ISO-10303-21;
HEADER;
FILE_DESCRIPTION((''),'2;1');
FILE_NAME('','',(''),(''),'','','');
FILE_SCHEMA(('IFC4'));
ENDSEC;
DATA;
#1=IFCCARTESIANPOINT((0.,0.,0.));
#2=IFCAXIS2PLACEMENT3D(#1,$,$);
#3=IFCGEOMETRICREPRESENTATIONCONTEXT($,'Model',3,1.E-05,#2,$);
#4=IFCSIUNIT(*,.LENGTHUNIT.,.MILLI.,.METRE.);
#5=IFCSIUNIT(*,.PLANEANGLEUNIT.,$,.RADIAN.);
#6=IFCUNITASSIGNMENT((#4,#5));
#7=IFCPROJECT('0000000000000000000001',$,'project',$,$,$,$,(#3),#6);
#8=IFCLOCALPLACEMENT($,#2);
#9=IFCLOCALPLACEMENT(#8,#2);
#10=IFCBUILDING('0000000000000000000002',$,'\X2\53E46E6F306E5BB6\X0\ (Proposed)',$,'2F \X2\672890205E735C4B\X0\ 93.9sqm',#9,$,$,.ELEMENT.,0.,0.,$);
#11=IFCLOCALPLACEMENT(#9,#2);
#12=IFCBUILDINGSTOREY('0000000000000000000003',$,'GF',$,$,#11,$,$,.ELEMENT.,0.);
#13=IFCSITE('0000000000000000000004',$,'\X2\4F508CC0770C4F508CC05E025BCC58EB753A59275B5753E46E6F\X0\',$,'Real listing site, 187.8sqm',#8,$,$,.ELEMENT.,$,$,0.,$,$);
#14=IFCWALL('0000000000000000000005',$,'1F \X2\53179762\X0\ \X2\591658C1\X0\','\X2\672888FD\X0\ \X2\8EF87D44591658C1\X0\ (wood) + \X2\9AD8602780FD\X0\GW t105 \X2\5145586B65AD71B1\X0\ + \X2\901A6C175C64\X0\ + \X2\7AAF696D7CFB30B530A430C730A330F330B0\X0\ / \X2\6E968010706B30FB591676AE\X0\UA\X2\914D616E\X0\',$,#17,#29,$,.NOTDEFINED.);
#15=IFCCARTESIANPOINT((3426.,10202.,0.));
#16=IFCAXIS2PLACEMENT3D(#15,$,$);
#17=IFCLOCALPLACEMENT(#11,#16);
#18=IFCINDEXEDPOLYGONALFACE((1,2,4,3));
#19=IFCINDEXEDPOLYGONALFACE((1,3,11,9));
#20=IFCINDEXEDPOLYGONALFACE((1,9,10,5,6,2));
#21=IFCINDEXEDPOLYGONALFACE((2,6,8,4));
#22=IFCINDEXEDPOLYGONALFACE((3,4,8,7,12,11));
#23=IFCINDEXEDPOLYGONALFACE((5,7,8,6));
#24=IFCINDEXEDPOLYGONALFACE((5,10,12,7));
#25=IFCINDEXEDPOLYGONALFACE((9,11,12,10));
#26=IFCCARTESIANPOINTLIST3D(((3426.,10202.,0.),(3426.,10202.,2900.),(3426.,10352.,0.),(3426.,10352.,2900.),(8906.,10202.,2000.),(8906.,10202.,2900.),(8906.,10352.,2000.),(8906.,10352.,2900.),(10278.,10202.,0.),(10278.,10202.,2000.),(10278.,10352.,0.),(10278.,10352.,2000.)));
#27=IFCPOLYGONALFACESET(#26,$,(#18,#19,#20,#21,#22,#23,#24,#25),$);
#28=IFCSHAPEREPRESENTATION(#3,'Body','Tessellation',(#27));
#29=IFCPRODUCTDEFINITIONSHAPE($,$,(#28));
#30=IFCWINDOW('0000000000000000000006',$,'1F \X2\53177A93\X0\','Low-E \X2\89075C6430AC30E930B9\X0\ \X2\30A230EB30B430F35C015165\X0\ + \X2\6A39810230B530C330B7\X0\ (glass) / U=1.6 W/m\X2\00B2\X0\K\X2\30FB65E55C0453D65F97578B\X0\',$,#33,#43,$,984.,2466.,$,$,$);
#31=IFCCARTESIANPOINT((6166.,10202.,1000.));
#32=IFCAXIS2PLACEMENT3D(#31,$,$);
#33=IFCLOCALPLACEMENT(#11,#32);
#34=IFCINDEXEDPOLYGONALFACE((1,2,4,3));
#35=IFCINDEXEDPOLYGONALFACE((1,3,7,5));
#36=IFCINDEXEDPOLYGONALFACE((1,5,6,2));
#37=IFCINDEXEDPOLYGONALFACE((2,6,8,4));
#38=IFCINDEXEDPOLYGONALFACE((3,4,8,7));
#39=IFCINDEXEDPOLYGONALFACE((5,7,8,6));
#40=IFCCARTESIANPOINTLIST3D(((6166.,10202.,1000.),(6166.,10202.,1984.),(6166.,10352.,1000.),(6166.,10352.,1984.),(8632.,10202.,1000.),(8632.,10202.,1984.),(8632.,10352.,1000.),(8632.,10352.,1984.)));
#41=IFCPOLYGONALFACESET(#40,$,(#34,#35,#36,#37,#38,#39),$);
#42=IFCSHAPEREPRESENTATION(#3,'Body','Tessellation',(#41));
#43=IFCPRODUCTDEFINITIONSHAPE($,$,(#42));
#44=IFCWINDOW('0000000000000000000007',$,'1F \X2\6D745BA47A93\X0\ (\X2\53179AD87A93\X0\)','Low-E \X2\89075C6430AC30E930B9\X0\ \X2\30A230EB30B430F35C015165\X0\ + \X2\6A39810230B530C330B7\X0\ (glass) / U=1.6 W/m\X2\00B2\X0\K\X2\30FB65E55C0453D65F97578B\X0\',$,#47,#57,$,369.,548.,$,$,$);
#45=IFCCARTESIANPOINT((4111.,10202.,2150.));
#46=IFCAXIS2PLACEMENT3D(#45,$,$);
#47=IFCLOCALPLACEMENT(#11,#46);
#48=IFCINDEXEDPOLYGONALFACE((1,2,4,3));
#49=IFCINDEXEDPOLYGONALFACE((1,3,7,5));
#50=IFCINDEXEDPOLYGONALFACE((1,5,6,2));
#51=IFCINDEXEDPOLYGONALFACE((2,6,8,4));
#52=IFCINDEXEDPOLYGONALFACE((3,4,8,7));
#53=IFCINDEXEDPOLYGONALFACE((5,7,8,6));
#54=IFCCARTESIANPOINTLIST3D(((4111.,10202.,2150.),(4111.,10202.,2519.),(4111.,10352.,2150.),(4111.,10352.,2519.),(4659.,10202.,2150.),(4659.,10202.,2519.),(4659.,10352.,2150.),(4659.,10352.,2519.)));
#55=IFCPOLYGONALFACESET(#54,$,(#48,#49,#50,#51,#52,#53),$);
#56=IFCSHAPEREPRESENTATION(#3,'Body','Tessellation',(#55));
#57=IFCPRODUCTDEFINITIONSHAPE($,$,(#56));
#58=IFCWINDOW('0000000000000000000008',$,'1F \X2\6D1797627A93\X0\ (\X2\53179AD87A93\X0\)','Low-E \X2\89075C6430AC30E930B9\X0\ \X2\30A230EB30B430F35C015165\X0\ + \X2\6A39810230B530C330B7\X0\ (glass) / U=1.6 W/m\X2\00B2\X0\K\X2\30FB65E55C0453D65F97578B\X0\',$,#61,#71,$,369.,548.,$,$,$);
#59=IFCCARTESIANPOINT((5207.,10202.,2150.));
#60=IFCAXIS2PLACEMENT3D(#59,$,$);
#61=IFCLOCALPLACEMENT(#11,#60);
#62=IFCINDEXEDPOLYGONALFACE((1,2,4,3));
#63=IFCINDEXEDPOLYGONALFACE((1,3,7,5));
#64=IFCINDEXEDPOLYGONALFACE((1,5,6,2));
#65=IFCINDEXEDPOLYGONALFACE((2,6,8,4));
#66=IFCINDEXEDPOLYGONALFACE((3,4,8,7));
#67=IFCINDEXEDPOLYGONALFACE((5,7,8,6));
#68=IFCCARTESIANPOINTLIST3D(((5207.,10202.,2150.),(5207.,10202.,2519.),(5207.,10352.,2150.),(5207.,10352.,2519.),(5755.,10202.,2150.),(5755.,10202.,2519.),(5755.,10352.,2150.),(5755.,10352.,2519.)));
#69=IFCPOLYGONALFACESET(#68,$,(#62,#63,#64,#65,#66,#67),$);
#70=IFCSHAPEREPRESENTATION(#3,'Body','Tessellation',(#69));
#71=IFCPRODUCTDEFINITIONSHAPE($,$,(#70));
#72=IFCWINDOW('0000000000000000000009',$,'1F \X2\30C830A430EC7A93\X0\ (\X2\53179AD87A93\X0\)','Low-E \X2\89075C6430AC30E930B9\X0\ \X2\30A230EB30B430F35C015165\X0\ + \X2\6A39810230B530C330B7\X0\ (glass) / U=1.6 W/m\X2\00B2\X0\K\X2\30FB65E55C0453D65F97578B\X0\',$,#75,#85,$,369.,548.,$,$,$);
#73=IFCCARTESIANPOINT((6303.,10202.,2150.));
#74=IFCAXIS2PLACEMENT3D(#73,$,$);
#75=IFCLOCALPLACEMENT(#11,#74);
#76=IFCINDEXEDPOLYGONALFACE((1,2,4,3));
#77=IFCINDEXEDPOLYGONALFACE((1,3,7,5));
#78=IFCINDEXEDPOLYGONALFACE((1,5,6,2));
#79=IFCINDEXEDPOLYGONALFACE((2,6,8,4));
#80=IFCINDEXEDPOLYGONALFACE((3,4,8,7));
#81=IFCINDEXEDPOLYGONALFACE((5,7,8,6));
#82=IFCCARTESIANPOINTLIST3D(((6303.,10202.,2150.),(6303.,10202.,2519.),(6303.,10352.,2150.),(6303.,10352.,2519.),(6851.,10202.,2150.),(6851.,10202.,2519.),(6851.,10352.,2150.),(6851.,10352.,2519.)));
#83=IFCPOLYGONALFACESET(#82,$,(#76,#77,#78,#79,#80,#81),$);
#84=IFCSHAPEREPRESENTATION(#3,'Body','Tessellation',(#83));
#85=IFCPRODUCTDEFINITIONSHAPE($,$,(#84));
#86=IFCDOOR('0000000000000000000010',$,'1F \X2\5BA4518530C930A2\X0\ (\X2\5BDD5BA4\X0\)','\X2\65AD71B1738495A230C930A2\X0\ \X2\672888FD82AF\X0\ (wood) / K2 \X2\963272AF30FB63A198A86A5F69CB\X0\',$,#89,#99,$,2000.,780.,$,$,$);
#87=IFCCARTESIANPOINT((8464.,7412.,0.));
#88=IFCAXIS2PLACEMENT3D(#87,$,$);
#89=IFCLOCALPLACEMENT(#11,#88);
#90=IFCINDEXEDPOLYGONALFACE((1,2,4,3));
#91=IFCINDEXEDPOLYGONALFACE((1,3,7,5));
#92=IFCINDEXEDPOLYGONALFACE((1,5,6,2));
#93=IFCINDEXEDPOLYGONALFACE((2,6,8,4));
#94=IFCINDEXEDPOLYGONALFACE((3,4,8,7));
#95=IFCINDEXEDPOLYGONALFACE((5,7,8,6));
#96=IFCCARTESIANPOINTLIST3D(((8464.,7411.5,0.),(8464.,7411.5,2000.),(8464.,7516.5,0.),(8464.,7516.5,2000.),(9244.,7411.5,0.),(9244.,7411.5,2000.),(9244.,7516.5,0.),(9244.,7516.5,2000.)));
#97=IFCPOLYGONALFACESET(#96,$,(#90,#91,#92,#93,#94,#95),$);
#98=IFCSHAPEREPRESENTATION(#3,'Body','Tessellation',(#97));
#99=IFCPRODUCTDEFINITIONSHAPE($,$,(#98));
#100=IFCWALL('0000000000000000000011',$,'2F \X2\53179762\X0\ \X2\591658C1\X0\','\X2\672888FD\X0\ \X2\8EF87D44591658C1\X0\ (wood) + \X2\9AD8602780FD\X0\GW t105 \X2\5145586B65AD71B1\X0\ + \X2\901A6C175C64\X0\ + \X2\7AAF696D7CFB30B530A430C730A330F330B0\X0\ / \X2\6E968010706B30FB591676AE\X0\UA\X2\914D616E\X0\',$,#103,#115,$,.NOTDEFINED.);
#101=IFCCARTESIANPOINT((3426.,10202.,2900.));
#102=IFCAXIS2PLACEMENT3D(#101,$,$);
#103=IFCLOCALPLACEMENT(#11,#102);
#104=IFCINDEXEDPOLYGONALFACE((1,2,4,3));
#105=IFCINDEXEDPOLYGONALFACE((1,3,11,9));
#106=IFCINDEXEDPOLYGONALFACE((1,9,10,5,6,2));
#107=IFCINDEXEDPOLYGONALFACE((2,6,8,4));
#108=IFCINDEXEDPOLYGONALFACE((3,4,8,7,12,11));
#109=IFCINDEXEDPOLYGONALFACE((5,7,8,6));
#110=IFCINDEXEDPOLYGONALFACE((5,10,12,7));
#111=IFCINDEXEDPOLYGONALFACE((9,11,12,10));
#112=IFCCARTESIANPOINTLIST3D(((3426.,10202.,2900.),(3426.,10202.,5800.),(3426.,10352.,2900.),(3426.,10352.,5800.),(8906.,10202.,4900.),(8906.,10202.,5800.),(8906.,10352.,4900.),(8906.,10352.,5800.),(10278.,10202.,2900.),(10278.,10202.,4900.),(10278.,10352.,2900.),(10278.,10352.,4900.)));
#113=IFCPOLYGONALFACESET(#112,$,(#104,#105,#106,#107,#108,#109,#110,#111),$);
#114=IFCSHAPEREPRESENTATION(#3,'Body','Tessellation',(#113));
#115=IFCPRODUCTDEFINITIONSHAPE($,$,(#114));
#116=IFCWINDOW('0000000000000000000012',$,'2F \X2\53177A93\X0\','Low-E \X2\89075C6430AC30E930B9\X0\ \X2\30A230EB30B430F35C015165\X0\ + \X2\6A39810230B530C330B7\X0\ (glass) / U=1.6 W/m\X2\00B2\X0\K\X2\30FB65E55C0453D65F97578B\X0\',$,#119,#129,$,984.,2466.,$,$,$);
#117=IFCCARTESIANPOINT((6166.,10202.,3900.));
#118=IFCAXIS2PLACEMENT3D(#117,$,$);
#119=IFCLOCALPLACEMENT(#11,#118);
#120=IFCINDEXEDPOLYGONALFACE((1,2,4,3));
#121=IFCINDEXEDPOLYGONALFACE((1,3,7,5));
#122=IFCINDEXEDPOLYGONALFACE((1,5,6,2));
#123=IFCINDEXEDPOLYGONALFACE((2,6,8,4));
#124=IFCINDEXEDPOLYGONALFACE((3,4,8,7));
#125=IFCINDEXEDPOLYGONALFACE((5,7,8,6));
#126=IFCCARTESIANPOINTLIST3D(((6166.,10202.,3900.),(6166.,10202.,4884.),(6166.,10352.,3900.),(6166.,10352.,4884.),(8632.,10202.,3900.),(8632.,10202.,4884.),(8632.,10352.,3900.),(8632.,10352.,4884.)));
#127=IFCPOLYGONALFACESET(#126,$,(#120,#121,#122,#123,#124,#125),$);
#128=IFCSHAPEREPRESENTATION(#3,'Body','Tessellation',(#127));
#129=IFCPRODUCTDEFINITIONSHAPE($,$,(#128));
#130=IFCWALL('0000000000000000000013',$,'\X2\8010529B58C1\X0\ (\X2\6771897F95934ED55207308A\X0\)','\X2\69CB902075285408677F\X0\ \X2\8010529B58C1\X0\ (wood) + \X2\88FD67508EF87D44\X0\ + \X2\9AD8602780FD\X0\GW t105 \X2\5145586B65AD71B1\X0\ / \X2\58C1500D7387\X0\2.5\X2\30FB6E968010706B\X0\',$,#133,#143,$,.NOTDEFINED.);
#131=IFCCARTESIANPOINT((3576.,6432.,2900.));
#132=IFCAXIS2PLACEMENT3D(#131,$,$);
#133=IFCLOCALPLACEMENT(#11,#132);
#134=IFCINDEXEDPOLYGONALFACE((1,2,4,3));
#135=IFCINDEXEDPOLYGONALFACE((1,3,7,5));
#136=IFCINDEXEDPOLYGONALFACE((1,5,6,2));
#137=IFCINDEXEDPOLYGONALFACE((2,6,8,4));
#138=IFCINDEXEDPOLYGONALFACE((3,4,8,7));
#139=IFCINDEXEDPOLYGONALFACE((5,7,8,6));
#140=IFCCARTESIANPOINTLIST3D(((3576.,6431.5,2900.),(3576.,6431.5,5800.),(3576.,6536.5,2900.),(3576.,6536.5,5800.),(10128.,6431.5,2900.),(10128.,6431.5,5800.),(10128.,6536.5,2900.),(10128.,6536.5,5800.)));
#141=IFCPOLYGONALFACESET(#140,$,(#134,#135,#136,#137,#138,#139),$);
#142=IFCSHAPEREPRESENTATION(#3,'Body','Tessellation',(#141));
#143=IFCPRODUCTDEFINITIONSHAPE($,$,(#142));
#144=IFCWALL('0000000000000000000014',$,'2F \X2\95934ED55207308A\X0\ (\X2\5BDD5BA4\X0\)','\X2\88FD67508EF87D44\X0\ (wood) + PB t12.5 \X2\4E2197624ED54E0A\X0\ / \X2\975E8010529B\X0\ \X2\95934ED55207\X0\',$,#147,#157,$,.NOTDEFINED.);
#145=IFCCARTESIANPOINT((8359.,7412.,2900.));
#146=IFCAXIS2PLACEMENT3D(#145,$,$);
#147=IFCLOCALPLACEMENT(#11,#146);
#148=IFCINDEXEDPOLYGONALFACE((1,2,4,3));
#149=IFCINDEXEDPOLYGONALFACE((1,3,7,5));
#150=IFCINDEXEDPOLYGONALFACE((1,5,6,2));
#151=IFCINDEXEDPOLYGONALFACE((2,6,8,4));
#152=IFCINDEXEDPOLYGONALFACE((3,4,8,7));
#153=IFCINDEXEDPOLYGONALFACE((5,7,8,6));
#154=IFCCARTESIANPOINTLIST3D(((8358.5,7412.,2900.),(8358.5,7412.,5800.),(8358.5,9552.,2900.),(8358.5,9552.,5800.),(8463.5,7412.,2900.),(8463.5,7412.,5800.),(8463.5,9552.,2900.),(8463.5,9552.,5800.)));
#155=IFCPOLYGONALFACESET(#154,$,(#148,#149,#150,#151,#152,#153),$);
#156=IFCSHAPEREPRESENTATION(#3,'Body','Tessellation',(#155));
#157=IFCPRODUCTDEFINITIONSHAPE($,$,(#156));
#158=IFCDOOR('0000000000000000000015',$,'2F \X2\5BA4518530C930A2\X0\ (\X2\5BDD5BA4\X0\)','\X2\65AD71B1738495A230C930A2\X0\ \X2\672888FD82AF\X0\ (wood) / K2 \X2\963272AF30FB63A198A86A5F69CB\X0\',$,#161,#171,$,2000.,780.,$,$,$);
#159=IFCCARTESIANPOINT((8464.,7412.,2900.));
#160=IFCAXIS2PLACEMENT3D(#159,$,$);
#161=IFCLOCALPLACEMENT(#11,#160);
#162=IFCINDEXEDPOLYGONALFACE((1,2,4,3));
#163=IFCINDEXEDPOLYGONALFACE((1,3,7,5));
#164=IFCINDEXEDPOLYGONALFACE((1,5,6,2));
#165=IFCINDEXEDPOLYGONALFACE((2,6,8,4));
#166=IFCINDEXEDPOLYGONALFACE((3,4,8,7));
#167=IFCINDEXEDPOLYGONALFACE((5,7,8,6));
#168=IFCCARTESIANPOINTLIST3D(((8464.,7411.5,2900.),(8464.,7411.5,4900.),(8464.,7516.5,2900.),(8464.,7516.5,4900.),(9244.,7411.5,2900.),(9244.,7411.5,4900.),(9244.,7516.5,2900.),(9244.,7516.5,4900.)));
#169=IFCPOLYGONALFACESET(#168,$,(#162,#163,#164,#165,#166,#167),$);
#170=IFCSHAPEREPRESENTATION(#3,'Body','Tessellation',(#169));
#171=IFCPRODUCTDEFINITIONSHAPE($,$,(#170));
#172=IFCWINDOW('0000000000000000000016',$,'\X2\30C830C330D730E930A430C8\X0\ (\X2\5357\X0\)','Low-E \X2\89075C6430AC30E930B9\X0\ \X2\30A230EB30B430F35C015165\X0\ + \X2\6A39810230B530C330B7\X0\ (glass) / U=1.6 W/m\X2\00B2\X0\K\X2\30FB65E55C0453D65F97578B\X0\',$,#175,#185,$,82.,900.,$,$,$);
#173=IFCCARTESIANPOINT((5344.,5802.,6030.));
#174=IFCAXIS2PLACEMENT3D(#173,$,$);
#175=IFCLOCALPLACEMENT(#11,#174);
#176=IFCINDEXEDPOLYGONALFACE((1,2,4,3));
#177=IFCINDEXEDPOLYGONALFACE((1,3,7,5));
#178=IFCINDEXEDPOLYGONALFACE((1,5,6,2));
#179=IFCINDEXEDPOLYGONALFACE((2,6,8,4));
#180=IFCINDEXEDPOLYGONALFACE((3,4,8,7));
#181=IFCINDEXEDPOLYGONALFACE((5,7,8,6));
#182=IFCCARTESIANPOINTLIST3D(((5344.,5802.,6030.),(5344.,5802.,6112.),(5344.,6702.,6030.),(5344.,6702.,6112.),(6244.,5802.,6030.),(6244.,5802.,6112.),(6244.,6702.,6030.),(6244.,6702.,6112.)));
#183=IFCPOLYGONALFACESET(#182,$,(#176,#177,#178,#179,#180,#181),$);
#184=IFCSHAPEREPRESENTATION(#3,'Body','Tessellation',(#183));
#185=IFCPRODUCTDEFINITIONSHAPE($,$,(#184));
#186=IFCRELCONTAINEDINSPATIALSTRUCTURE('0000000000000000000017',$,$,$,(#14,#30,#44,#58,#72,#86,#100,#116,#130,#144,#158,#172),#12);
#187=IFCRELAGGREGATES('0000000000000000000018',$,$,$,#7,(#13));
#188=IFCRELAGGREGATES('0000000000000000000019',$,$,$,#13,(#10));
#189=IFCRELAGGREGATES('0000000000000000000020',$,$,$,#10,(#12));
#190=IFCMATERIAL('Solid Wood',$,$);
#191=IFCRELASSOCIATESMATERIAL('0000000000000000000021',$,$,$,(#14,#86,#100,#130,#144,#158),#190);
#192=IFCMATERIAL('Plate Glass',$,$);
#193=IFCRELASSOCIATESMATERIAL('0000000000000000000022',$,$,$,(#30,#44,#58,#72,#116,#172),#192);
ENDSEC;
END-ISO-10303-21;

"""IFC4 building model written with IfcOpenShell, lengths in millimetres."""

from ifc_helpers import new_model, si_unit, frame, frame_2d, origin, place, context, project, spatial, rectangle, extrude, material, element, fill, save


model = new_model("IFC4")

# Units and contexts
model_context = context("Model", 3, precision=1e-05, world=origin())
ifc_project = project(units=[si_unit("LENGTHUNIT", "METRE", prefix="MILLI"), si_unit("PLANEANGLEUNIT", "RADIAN")], contexts=[model_context])

# Site, building, storey
site_placement = place(None, origin())
site = spatial("IfcSite", under=ifc_project, at=site_placement, Name="佐賀県佐賀市富士町大字古湯", ObjectType="Real listing site, 187.8sqm", CompositionType="ELEMENT", RefElevation=0.0)
building_placement = place(site_placement, origin())
building = spatial("IfcBuilding", under=site, at=building_placement, Name="古湯の家 (Proposed)", ObjectType="2F 木造平屋 93.9sqm", CompositionType="ELEMENT", ElevationOfRefHeight=0.0, ElevationOfTerrain=0.0)
storey_placement = place(building_placement, origin())
storey = spatial("IfcBuildingStorey", under=building, at=storey_placement, Name="GF", CompositionType="ELEMENT", Elevation=0.0)

# Wall, openings, windows
ifc_material_1 = material(Name="Solid Wood")
wall_1_placement = place(storey_placement, frame((3426.0, 10202.0, 0.0)))
wall_1 = element("IfcWall", 1, at=wall_1_placement, inside=storey, material=ifc_material_1, Name="1F 北面 外壁", Description="木製 軸組外壁 (wood) + 高性能GW t105 充填断熱 + 通気層 + 窯業系サイディング / 準耐火・外皮UA配慮", PredefinedType="NOTDEFINED", context=model_context, shape_type="SweptSolid", body=[
    extrude(rectangle(XDim=6852.0, YDim=150.0, at=frame_2d((3426.0, 75.0))), frame((3426.0, 10202.0, 0.0)), (0.0, 0.0, 1.0), 2900.0),
])
opening_1_placement = place(storey_placement, frame((6166.0, 10202.0, 1000.0)))
opening_1 = element("IfcOpeningElement", 2, at=opening_1_placement, cuts=wall_1, PredefinedType="NOTDEFINED", context=model_context, shape_type="SweptSolid", body=[
    extrude(rectangle(XDim=2466.0, YDim=150.0, at=frame_2d((1233.0, 75.0))), frame((6166.0, 10202.0, 1000.0)), (0.0, 0.0, 1.0), 984.0),
])
opening_2_placement = place(storey_placement, frame((4111.0, 10202.0, 2150.0)))
opening_2 = element("IfcOpeningElement", 3, at=opening_2_placement, cuts=wall_1, PredefinedType="NOTDEFINED", context=model_context, shape_type="SweptSolid", body=[
    extrude(rectangle(XDim=548.0, YDim=150.0, at=frame_2d((274.0, 75.0))), frame((4111.0, 10202.0, 2150.0)), (0.0, 0.0, 1.0), 369.0),
])
opening_3_placement = place(storey_placement, frame((5207.0, 10202.0, 2150.0)))
opening_3 = element("IfcOpeningElement", 4, at=opening_3_placement, cuts=wall_1, PredefinedType="NOTDEFINED", context=model_context, shape_type="SweptSolid", body=[
    extrude(rectangle(XDim=548.0, YDim=150.0, at=frame_2d((274.0, 75.0))), frame((5207.0, 10202.0, 2150.0)), (0.0, 0.0, 1.0), 369.0),
])
opening_4_placement = place(storey_placement, frame((6303.0, 10202.0, 2150.0)))
opening_4 = element("IfcOpeningElement", 5, at=opening_4_placement, cuts=wall_1, PredefinedType="NOTDEFINED", context=model_context, shape_type="SweptSolid", body=[
    extrude(rectangle(XDim=548.0, YDim=150.0, at=frame_2d((274.0, 75.0))), frame((6303.0, 10202.0, 2150.0)), (0.0, 0.0, 1.0), 369.0),
])
ifc_material_2 = material(Name="Plate Glass")
window_1_placement = place(storey_placement, frame((6166.0, 10202.0, 1000.0)))
window_1 = element("IfcWindow", 6, at=window_1_placement, inside=storey, material=ifc_material_2, Name="1F 北窓", Description="Low-E 複層ガラス アルゴン封入 + 樹脂サッシ (glass) / U=1.6 W/m²K・日射取得型", OverallHeight=984.0, OverallWidth=2466.0, context=model_context, shape_type="SweptSolid", body=[
    extrude(rectangle(XDim=2466.0, YDim=150.0, at=frame_2d((1233.0, 75.0))), frame((6166.0, 10202.0, 1000.0)), (0.0, 0.0, 1.0), 984.0),
])
fill(opening_1, window_1)
window_2_placement = place(storey_placement, frame((4111.0, 10202.0, 2150.0)))
window_2 = element("IfcWindow", 7, at=window_2_placement, inside=storey, material=ifc_material_2, Name="1F 浴室窓 (北高窓)", Description="Low-E 複層ガラス アルゴン封入 + 樹脂サッシ (glass) / U=1.6 W/m²K・日射取得型", OverallHeight=369.0, OverallWidth=548.0, context=model_context, shape_type="SweptSolid", body=[
    extrude(rectangle(XDim=548.0, YDim=150.0, at=frame_2d((274.0, 75.0))), frame((4111.0, 10202.0, 2150.0)), (0.0, 0.0, 1.0), 369.0),
])
fill(opening_2, window_2)
window_3_placement = place(storey_placement, frame((5207.0, 10202.0, 2150.0)))
window_3 = element("IfcWindow", 8, at=window_3_placement, inside=storey, material=ifc_material_2, Name="1F 洗面窓 (北高窓)", Description="Low-E 複層ガラス アルゴン封入 + 樹脂サッシ (glass) / U=1.6 W/m²K・日射取得型", OverallHeight=369.0, OverallWidth=548.0, context=model_context, shape_type="SweptSolid", body=[
    extrude(rectangle(XDim=548.0, YDim=150.0, at=frame_2d((274.0, 75.0))), frame((5207.0, 10202.0, 2150.0)), (0.0, 0.0, 1.0), 369.0),
])
fill(opening_3, window_3)
window_4_placement = place(storey_placement, frame((6303.0, 10202.0, 2150.0)))
window_4 = element("IfcWindow", 9, at=window_4_placement, inside=storey, material=ifc_material_2, Name="1F トイレ窓 (北高窓)", Description="Low-E 複層ガラス アルゴン封入 + 樹脂サッシ (glass) / U=1.6 W/m²K・日射取得型", OverallHeight=369.0, OverallWidth=548.0, context=model_context, shape_type="SweptSolid", body=[
    extrude(rectangle(XDim=548.0, YDim=150.0, at=frame_2d((274.0, 75.0))), frame((6303.0, 10202.0, 2150.0)), (0.0, 0.0, 1.0), 369.0),
])
fill(opening_4, window_4)

# Door
door_1_placement = place(storey_placement, frame((8464.0, 7412.0, 0.0)))
element("IfcDoor", 10, at=door_1_placement, inside=storey, material=ifc_material_1, Name="1F 室内ドア (寝室)", Description="断熱玄関ドア 木製芯 (wood) / K2 防犯・採風機構", OverallHeight=2000.0, OverallWidth=780.0, context=model_context, shape_type="SweptSolid", body=[
    extrude(rectangle(XDim=780.0, YDim=105.0, at=frame_2d((390.0, 52.0))), frame((8464.0, 7412.0, 0.0)), (0.0, 0.0, 1.0), 2000.0),
])

# Wall, opening, window
wall_2_placement = place(storey_placement, frame((3426.0, 10202.0, 2900.0)))
wall_2 = element("IfcWall", 11, at=wall_2_placement, inside=storey, material=ifc_material_1, Name="2F 北面 外壁", Description="木製 軸組外壁 (wood) + 高性能GW t105 充填断熱 + 通気層 + 窯業系サイディング / 準耐火・外皮UA配慮", PredefinedType="NOTDEFINED", context=model_context, shape_type="SweptSolid", body=[
    extrude(rectangle(XDim=6852.0, YDim=150.0, at=frame_2d((3426.0, 75.0))), frame((3426.0, 10202.0, 2900.0)), (0.0, 0.0, 1.0), 2900.0),
])
opening_5_placement = place(storey_placement, frame((6166.0, 10202.0, 3900.0)))
opening_5 = element("IfcOpeningElement", 12, at=opening_5_placement, cuts=wall_2, PredefinedType="NOTDEFINED", context=model_context, shape_type="SweptSolid", body=[
    extrude(rectangle(XDim=2466.0, YDim=150.0, at=frame_2d((1233.0, 75.0))), frame((6166.0, 10202.0, 3900.0)), (0.0, 0.0, 1.0), 984.0),
])
window_5_placement = place(storey_placement, frame((6166.0, 10202.0, 3900.0)))
window_5 = element("IfcWindow", 13, at=window_5_placement, inside=storey, material=ifc_material_2, Name="2F 北窓", Description="Low-E 複層ガラス アルゴン封入 + 樹脂サッシ (glass) / U=1.6 W/m²K・日射取得型", OverallHeight=984.0, OverallWidth=2466.0, context=model_context, shape_type="SweptSolid", body=[
    extrude(rectangle(XDim=2466.0, YDim=150.0, at=frame_2d((1233.0, 75.0))), frame((6166.0, 10202.0, 3900.0)), (0.0, 0.0, 1.0), 984.0),
])
fill(opening_5, window_5)

# Walls
wall_3_placement = place(storey_placement, frame((3576.0, 6432.0, 2900.0)))
element("IfcWall", 14, at=wall_3_placement, inside=storey, material=ifc_material_1, Name="耐力壁 (東西間仕切り)", Description="構造用合板 耐力壁 (wood) + 製材軸組 + 高性能GW t105 充填断熱 / 壁倍率2.5・準耐火", PredefinedType="NOTDEFINED", context=model_context, shape_type="SweptSolid", body=[
    extrude(rectangle(XDim=6552.0, YDim=105.0, at=frame_2d((3276.0, 52.0))), frame((3576.0, 6432.0, 2900.0)), (0.0, 0.0, 1.0), 2900.0),
])
wall_4_placement = place(storey_placement, frame((8359.0, 7412.0, 2900.0)))
element("IfcWall", 15, at=wall_4_placement, inside=storey, material=ifc_material_1, Name="2F 間仕切り (寝室)", Description="製材軸組 (wood) + PB t12.5 両面仕上 / 非耐力 間仕切", PredefinedType="NOTDEFINED", context=model_context, shape_type="SweptSolid", body=[
    extrude(rectangle(XDim=105.0, YDim=2140.0, at=frame_2d((52.0, 1070.0))), frame((8359.0, 7412.0, 2900.0)), (0.0, 0.0, 1.0), 2900.0),
])

# Door
door_2_placement = place(storey_placement, frame((8464.0, 7412.0, 2900.0)))
element("IfcDoor", 16, at=door_2_placement, inside=storey, material=ifc_material_1, Name="2F 室内ドア (寝室)", Description="断熱玄関ドア 木製芯 (wood) / K2 防犯・採風機構", OverallHeight=2000.0, OverallWidth=780.0, context=model_context, shape_type="SweptSolid", body=[
    extrude(rectangle(XDim=780.0, YDim=105.0, at=frame_2d((390.0, 52.0))), frame((8464.0, 7412.0, 2900.0)), (0.0, 0.0, 1.0), 2000.0),
])

# Window
window_6_placement = place(storey_placement, frame((5344.0, 5802.0, 6030.0)))
element("IfcWindow", 17, at=window_6_placement, inside=storey, material=ifc_material_2, Name="トップライト (南)", Description="Low-E 複層ガラス アルゴン封入 + 樹脂サッシ (glass) / U=1.6 W/m²K・日射取得型", OverallHeight=82.0, OverallWidth=900.0, context=model_context, shape_type="SweptSolid", body=[
    extrude(rectangle(XDim=900.0, YDim=900.0, at=frame_2d((450.0, 450.0))), frame((5344.0, 5802.0, 6030.0)), (0.0, 0.0, 1.0), 82.0),
])

save(model, "model.ifc")
